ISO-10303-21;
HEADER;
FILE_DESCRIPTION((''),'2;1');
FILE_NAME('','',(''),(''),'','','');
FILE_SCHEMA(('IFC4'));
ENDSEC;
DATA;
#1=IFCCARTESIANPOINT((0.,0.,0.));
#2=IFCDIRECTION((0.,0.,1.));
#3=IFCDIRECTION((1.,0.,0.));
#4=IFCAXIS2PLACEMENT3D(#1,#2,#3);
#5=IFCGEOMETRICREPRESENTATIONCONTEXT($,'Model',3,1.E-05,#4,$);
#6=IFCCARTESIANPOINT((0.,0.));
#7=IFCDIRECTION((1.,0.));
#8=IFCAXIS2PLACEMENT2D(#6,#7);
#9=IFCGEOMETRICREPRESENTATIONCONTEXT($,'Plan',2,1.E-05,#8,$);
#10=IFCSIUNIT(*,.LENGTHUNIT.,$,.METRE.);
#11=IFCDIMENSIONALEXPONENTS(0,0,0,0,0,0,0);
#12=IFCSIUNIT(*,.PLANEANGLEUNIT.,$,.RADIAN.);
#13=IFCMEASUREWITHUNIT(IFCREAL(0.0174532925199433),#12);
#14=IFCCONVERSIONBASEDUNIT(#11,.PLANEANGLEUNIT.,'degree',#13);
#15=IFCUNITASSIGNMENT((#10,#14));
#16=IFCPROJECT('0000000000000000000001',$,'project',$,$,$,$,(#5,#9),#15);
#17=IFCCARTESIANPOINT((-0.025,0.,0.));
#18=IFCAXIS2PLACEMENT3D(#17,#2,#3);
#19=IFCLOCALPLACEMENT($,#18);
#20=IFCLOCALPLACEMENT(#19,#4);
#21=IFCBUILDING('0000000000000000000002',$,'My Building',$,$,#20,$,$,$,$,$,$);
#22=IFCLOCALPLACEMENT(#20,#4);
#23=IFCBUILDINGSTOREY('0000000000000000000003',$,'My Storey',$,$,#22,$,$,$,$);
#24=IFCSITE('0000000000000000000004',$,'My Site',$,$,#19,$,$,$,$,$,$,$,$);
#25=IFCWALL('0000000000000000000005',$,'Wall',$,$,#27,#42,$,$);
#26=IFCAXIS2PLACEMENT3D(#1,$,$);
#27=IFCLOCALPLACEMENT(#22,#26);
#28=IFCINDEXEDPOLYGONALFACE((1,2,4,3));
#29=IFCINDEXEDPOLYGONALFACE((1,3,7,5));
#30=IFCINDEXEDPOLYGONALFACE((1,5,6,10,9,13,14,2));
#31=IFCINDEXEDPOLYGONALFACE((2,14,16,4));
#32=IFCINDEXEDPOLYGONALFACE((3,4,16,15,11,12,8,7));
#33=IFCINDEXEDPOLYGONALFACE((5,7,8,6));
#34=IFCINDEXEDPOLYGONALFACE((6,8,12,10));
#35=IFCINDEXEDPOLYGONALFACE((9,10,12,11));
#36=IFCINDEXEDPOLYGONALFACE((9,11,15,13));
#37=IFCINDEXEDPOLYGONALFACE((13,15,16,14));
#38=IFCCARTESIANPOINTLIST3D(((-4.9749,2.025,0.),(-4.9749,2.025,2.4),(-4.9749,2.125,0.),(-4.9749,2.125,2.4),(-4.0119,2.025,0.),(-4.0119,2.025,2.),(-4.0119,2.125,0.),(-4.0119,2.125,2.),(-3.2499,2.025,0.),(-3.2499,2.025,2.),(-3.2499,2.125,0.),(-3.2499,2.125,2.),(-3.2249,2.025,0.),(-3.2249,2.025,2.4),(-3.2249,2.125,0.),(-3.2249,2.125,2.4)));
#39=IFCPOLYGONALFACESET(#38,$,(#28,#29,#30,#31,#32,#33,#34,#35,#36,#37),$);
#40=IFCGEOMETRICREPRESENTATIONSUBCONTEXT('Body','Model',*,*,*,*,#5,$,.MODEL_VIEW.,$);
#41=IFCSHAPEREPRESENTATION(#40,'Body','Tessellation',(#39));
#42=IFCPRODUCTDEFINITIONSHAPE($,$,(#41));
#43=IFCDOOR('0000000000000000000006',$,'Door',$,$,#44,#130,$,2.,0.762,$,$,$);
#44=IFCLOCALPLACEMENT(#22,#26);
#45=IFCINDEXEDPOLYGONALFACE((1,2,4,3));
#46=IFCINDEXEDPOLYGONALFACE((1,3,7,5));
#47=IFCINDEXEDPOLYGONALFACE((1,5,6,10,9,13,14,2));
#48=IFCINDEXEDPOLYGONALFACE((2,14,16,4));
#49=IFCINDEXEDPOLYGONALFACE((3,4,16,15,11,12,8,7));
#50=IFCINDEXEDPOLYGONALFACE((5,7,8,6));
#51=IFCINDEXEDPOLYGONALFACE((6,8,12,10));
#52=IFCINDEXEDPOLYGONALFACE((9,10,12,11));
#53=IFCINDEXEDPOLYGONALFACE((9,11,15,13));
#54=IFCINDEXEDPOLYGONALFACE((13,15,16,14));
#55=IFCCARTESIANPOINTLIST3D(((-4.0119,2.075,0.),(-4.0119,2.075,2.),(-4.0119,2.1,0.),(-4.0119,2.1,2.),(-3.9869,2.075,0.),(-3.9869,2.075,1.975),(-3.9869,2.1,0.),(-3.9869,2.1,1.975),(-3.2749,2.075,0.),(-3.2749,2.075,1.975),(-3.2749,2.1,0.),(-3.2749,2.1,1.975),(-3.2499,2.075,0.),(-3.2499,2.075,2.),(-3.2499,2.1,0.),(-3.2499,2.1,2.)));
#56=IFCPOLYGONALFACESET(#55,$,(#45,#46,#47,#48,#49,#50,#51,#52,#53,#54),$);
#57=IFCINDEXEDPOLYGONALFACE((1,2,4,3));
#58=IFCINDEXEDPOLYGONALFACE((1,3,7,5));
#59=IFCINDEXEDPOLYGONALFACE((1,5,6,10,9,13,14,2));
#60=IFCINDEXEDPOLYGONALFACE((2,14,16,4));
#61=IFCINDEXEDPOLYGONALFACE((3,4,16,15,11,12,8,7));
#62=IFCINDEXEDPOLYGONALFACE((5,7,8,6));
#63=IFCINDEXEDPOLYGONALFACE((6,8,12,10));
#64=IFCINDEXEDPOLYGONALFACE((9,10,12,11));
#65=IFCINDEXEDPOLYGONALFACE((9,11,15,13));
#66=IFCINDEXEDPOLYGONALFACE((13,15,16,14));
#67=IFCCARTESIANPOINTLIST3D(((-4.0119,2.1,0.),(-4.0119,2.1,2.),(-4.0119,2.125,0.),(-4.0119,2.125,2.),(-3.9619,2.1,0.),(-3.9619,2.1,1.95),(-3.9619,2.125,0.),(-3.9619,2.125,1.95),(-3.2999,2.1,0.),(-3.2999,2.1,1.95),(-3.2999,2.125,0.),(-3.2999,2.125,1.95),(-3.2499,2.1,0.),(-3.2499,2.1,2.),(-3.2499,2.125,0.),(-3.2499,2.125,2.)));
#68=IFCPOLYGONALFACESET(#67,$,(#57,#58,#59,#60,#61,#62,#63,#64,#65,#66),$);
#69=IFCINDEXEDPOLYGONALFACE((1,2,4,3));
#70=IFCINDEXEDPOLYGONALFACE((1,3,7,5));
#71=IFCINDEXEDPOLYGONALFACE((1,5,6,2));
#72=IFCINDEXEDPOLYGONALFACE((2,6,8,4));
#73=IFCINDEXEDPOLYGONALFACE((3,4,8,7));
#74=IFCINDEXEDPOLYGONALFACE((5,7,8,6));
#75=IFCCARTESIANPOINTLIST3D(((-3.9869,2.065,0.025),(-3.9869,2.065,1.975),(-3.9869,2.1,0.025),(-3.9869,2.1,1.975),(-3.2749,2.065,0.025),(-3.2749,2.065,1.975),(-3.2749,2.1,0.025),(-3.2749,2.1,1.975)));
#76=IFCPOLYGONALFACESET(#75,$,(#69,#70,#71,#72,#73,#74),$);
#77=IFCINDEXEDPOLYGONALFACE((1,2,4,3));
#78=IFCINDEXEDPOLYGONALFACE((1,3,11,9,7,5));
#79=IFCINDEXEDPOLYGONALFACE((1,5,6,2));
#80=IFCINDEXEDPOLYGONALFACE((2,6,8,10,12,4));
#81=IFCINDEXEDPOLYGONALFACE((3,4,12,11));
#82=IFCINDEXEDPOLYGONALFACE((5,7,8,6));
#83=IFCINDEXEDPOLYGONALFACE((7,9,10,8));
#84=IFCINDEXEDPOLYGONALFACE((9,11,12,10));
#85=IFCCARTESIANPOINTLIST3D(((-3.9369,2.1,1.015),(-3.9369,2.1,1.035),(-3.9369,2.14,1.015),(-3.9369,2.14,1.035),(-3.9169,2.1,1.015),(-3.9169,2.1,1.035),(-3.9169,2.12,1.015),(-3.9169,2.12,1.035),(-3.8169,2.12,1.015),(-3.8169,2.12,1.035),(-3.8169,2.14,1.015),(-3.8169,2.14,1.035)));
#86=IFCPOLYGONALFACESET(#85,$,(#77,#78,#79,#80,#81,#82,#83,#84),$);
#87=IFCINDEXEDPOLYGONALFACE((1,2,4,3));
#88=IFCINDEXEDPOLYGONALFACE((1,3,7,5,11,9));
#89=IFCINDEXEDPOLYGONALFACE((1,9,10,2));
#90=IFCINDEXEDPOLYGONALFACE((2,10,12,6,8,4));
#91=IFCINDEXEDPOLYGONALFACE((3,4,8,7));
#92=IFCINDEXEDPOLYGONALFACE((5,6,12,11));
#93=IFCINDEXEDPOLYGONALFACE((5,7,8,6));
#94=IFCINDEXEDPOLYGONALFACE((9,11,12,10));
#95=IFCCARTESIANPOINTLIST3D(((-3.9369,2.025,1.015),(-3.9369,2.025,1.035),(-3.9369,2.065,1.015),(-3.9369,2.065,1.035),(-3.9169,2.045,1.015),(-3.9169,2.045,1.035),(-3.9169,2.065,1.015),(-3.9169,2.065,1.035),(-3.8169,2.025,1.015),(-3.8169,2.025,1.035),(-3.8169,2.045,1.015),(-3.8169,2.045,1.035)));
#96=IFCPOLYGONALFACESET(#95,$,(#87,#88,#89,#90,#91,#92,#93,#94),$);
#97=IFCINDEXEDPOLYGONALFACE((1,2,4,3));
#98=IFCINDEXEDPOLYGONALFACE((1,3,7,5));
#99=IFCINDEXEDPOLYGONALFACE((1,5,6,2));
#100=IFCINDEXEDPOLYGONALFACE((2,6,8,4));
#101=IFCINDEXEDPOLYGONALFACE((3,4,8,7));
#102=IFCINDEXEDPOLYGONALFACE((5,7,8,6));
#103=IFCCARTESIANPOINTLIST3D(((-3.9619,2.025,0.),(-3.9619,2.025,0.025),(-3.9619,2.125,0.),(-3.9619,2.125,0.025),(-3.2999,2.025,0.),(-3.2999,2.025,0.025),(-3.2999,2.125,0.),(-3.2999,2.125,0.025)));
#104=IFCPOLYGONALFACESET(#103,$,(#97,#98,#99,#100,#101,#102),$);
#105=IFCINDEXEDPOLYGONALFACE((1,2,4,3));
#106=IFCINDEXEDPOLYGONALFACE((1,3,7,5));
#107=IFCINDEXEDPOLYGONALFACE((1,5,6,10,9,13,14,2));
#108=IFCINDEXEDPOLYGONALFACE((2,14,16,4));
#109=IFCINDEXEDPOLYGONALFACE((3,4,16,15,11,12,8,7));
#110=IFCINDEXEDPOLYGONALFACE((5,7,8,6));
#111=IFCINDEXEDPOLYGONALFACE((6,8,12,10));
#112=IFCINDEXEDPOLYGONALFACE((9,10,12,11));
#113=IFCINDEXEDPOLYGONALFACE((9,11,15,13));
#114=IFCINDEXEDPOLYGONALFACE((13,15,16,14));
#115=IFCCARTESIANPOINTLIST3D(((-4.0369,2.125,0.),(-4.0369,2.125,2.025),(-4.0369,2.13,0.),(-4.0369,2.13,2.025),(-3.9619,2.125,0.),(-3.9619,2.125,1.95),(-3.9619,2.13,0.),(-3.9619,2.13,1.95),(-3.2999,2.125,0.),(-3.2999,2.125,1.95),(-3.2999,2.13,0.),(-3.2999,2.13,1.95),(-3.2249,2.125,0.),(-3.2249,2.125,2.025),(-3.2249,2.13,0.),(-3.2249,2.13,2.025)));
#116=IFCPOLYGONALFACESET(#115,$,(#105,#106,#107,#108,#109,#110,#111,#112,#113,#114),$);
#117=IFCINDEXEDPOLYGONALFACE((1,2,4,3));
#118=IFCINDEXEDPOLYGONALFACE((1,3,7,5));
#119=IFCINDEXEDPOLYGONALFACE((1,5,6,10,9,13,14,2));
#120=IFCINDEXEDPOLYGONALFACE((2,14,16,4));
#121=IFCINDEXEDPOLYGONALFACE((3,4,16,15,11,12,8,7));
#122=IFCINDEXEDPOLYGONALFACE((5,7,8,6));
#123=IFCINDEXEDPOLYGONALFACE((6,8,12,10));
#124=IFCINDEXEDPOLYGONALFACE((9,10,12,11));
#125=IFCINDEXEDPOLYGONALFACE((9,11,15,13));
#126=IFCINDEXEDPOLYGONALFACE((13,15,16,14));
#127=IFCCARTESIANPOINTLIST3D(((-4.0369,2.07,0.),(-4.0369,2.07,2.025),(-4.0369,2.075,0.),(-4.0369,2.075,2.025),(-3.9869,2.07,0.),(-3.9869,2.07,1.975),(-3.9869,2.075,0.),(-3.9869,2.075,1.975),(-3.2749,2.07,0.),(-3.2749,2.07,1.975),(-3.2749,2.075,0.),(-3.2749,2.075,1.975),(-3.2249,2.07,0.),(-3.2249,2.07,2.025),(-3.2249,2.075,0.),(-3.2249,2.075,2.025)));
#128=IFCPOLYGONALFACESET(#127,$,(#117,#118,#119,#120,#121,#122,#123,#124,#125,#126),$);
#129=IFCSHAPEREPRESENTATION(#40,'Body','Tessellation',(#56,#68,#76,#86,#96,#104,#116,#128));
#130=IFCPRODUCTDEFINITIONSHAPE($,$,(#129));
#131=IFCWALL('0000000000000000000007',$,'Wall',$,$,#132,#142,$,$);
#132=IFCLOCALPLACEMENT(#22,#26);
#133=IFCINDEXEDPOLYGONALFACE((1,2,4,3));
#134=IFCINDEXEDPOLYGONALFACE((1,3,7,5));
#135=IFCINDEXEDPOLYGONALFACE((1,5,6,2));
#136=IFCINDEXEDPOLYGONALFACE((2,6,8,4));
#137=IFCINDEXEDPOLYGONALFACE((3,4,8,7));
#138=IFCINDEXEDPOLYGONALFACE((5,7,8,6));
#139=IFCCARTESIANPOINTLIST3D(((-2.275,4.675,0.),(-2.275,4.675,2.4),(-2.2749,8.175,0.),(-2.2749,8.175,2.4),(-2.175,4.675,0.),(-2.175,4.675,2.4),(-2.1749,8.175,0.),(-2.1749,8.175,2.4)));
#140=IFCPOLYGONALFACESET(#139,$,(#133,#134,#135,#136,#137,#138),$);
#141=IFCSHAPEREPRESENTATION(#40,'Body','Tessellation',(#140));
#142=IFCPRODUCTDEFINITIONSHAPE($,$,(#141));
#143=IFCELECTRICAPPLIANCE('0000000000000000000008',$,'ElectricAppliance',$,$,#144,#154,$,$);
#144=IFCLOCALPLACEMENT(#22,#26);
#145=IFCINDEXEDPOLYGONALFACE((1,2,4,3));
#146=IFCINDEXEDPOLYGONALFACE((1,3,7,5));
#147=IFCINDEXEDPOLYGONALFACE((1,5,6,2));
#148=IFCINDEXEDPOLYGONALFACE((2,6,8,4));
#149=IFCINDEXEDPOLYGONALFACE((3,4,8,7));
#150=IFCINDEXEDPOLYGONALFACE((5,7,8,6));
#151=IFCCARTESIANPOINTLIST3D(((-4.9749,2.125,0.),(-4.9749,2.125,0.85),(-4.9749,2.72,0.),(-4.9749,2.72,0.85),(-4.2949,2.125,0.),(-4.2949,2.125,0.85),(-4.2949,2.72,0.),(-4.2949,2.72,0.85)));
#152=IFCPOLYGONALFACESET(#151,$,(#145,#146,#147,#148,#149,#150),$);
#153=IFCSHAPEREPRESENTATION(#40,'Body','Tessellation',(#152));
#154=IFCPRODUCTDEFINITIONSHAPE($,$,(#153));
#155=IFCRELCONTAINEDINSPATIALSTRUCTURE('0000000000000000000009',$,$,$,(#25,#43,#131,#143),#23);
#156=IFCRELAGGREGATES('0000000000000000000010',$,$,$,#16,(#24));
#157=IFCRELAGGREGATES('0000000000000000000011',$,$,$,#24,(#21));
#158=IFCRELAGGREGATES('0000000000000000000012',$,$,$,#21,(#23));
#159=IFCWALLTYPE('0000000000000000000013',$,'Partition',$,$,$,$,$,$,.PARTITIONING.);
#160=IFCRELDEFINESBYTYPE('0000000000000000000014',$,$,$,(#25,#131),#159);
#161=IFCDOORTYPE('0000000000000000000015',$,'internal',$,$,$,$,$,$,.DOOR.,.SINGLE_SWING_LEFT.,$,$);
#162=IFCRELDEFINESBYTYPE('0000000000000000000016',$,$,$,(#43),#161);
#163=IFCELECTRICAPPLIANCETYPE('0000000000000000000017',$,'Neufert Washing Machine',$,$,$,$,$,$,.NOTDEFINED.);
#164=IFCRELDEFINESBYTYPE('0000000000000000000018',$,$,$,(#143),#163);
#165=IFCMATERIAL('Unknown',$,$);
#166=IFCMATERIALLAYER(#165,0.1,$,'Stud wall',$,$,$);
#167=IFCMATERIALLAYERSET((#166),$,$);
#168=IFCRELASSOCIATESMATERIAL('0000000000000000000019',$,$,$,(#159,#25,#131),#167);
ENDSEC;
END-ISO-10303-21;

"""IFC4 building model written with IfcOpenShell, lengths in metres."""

from ifc_helpers import new_model, entity, si_unit, converted_unit, frame, origin_with_axes, origin_2d_with_axis, place, context, subcontext, project, spatial, line, indexed_curve, outline, extrude, shape, source, transform, mapped, material, layer, layer_set, layer_usage, type_object, type_shapes, element, fill, save


model = new_model("IFC4")

# Units and contexts
model_context = context("Model", 3, precision=1e-05, world=origin_with_axes())
plan_context = context("Plan", 2, precision=1e-05, world=origin_2d_with_axis())
body_context_1 = subcontext(model_context, "Body", "Model", "MODEL_VIEW")
body_context_2 = subcontext(plan_context, "Body", "Plan", "PLAN_VIEW")
ifc_project = project(units=[si_unit("LENGTHUNIT", "METRE"), converted_unit("PLANEANGLEUNIT", "degree", entity("IfcReal", 0.0174532925199433), si_unit("PLANEANGLEUNIT", "RADIAN"), dimensions=[0, 0, 0, 0, 0, 0, 0])], contexts=[model_context, plan_context])

# Site, building, storey
site_placement = place(None, frame((-0.025, 0.0, 0.0), z_axis=(0.0, 0.0, 1.0), x_axis=(1.0, 0.0, 0.0)))
site = spatial("IfcSite", under=ifc_project, at=site_placement, Name="My Site")
building_placement = place(site_placement, origin_with_axes())
building = spatial("IfcBuilding", under=site, at=building_placement, Name="My Building")
storey_placement = place(building_placement, origin_with_axes())
storey = spatial("IfcBuildingStorey", under=building, at=storey_placement, Name="My Storey")

# Shared definitions
ifc_material = material(Name="Unknown")
shared_shape_1 = source(origin_with_axes(), body_context_1, "Body", "SweptSolid", [
    extrude(outline(indexed_curve([(0.0, 0.0), (0.762, 0.0), (0.762, 2.0), (0.0, 2.0)], segments=[line(1, 2, 3, 4, 1)])), frame((0.0, -0.6, 0.0), z_axis=(0.0, -1.0, 0.0), x_axis=(1.0, 0.0, 0.0)), (0.0, 0.0, -1.0), 1.2),
])
door_type = type_object("IfcDoorType", Name="internal", OperationType="SINGLE_SWING_LEFT", PredefinedType="DOOR")
shared_shape_2 = source(origin_with_axes(), body_context_1, "Body", "SweptSolid", [
    extrude(outline(indexed_curve([(0.0, 0.0), (0.0, 2.0), (0.762, 2.0), (0.762, 0.0), (0.737, 0.0), (0.737, 1.975), (0.025, 1.975), (0.025, 0.0)], segments=[line(1, 2, 3, 4, 5, 6, 7, 8, 1)])), frame((0.0, 0.025, 0.0), z_axis=(0.0, -1.0, 0.0), x_axis=(1.0, 0.0, 0.0)), (0.0, 0.0, -1.0), 0.025),
    extrude(outline(indexed_curve([(0.0, 0.0), (0.0, 2.0), (0.762, 2.0), (0.762, 0.0), (0.712, 0.0), (0.712, 1.95), (0.05, 1.95), (0.05, 0.0)], segments=[line(1, 2, 3, 4, 5, 6, 7, 8, 1)])), frame((0.0, 0.0, 0.0), z_axis=(0.0, -1.0, 0.0), x_axis=(1.0, 0.0, 0.0)), (0.0, 0.0, -1.0), 0.025),
    extrude(outline(indexed_curve([(0.0, 0.0), (0.712, 0.0), (0.712, 0.035), (0.0, 0.035)], segments=[line(1, 2, 3, 4, 1)])), frame((0.025, 0.025, 0.025), z_axis=(0.0, 0.0, 1.0), x_axis=(1.0, 0.0, 0.0)), (0.0, 0.0, 1.0), 1.95),
    extrude(outline(indexed_curve([(0.0, 0.0), (0.0, -0.04), (-0.12, -0.04), (-0.12, -0.02), (-0.02, -0.02), (-0.02, 0.0)], segments=[line(1, 2, 3, 4, 5, 6, 1)])), frame((0.687, 0.025, 1.015), z_axis=(0.0, 0.0, 1.0), x_axis=(1.0, 0.0, 0.0)), (0.0, 0.0, 1.0), 0.02),
    extrude(outline(indexed_curve([(0.0, 0.0), (0.0, 0.04), (-0.12, 0.04), (-0.12, 0.02), (-0.02, 0.02), (-0.02, 0.0)], segments=[line(1, 2, 3, 4, 5, 6, 1)])), frame((0.687, 0.06, 1.015), z_axis=(0.0, 0.0, 1.0), x_axis=(1.0, 0.0, 0.0)), (0.0, 0.0, 1.0), 0.02),
    extrude(outline(indexed_curve([(0.0, 0.0), (0.662, 0.0), (0.662, 0.1), (0.0, 0.1)], segments=[line(1, 2, 3, 4, 1)])), frame((0.05, 0.0, 0.0), z_axis=(0.0, 0.0, 1.0), x_axis=(1.0, 0.0, 0.0)), (0.0, 0.0, 1.0), 0.025),
    extrude(outline(indexed_curve([(0.0, 0.0), (0.0, 2.025), (0.812, 2.025), (0.812, 0.0), (0.737, 0.0), (0.737, 1.95), (0.075, 1.95), (0.075, 0.0)], segments=[line(1, 2, 3, 4, 5, 6, 7, 8, 1)])), frame((-0.025, -0.005, 0.0), z_axis=(0.0, -1.0, 0.0), x_axis=(1.0, 0.0, 0.0)), (0.0, 0.0, -1.0), 0.005),
    extrude(outline(indexed_curve([(0.0, 0.0), (0.0, 2.025), (0.812, 2.025), (0.812, 0.0), (0.762, 0.0), (0.762, 1.975), (0.05, 1.975), (0.05, 0.0)], segments=[line(1, 2, 3, 4, 5, 6, 7, 8, 1)])), frame((-0.025, 0.05, 0.0), z_axis=(0.0, -1.0, 0.0), x_axis=(1.0, 0.0, 0.0)), (0.0, 0.0, -1.0), 0.005),
])
shared_shape_3 = source(origin_with_axes(), body_context_2, "Body", "Curve2D", [
    entity("IfcIndexedPolyCurve", entity("IfcCartesianPointList2D", [[0.0, 0.0], [0.0, 0.05], [0.025, 0.05], [0.025, 0.025], [0.05, 0.025], [0.05, 0.0]]), [entity("IfcLineIndex", [1, 2, 3, 4, 5, 6, 1])]),
    entity("IfcIndexedPolyCurve", entity("IfcCartesianPointList2D", [[0.762, 0.0], [0.762, 0.05], [0.737, 0.05], [0.737, 0.025], [0.712, 0.025], [0.712, 0.0]]), [entity("IfcLineIndex", [1, 2, 3, 4, 5, 6, 1])]),
    entity("IfcTrimmedCurve", entity("IfcEllipse", entity("IfcAxis2Placement2D", entity("IfcCartesianPoint", [0.06, 0.05]), entity("IfcDirection", [1.0, 0.0])), 0.677, 0.712), [entity("IfcCartesianPoint", [0.737, 0.05])], [entity("IfcCartesianPoint", [0.06, 0.762])], True, "CARTESIAN"),
    entity("IfcIndexedPolyCurve", entity("IfcCartesianPointList2D", [[0.025, 0.05], [0.06, 0.05], [0.06, 0.762], [0.025, 0.762]]), [entity("IfcLineIndex", [1, 2, 3, 4, 1])]),
])
type_shapes(door_type, [shared_shape_2, shared_shape_3])

# Wall, opening, door
ifc_layer_1 = layer(ifc_material, 0.1, Name="Stud wall")
ifc_layer_set_1 = layer_set([ifc_layer_1])
wall_type_1 = type_object("IfcWallType", Name="Partition", PredefinedType="PARTITIONING", material=ifc_layer_set_1)
ifc_layer_usage_1 = layer_usage(ifc_layer_set_1, "AXIS2", "POSITIVE", 0.0)
wall_1_placement = place(storey_placement, frame((-3.2249, 2.125, 0.0), z_axis=(0.0, 0.0, 1.0), x_axis=(-1.0, 0.0, 0.0)))
wall_1 = element("IfcWall", 1, at=wall_1_placement, inside=storey, type_object=wall_type_1, material=ifc_layer_usage_1, Name="Wall", context=body_context_1, shape_type="SweptSolid", body=[
    extrude(outline(indexed_curve([(0.0, 0.0), (0.0, 0.1), (1.75, 0.1), (1.75, 0.0), (0.0, 0.0)], self_intersect=False)), origin_with_axes(), (0.0, 0.0, 1.0), 2.4),
])
opening_1_placement = place(wall_1_placement, frame((0.025, 0.0, 0.0), z_axis=(0.0, 0.0, 1.0), x_axis=(1.0, 0.0, 0.0)))
opening_1 = element("IfcOpeningElement", 2, at=opening_1_placement, cuts=wall_1, PredefinedType="OPENING", context=body_context_1, shape_type="MappedRepresentation", body=[
    mapped(shared_shape_1, transform((0.0, 0.0, 0.0), x_axis=(1.0, 0.0, 0.0), y_axis=(0.0, 1.0, 0.0), z_axis=(0.0, 0.0, 1.0), scale=1.0)),
])
door_1_placement = place(opening_1_placement, frame((0.0, 0.0, 0.0), z_axis=(0.0, 0.0, 1.0), x_axis=(1.0, 0.0, 0.0)))
door_1 = element("IfcDoor", 3, at=door_1_placement, inside=storey, type_object=door_type, Name="Door", OverallHeight=2.0, OverallWidth=0.762, shapes=[
    shape(body_context_1, "Body", "MappedRepresentation", [mapped(shared_shape_2, transform((0.0, 0.0, 0.0), x_axis=(1.0, 0.0, 0.0), y_axis=(0.0, 1.0, 0.0), z_axis=(0.0, 0.0, 1.0), scale=1.0))]),
    shape(body_context_2, "Body", "MappedRepresentation", [mapped(shared_shape_3, transform((0.0, 0.0, 0.0), x_axis=(1.0, 0.0, 0.0), y_axis=(0.0, 1.0, 0.0), z_axis=(0.0, 0.0, 1.0), scale=1.0))]),
])
fill(opening_1, door_1)

# Wall
ifc_layer_usage_2 = layer_usage(ifc_layer_set_1, "AXIS2", "POSITIVE", 0.0)
wall_2_placement = place(storey_placement, frame((-2.175, 4.675, 0.0), z_axis=(0.0, 0.0, 1.0), x_axis=(0.0, 1.0, 0.0)))
element("IfcWall", 4, at=wall_2_placement, inside=storey, type_object=wall_type_1, material=ifc_layer_usage_2, Name="Wall", context=body_context_1, shape_type="SweptSolid", body=[
    extrude(outline(indexed_curve([(0.0, 0.0), (0.0, 0.1), (3.5, 0.1), (3.5, 0.0), (0.0, 0.0)], self_intersect=False)), origin_with_axes(), (0.0, 0.0, 1.0), 2.4),
])

# Electric appliance
electric_appliance_type_1 = type_object("IfcElectricApplianceType", Name="Neufert Washing Machine", PredefinedType="NOTDEFINED")
shared_shape_4 = source(origin_with_axes(), body_context_1, "Body", "SweptSolid", [
    extrude(outline(indexed_curve([(0.0, 0.0), (0.595, 0.0), (0.595, 0.68), (0.0, 0.68)], segments=[line(1, 2, 3, 4, 1)])), origin_with_axes(), (0.0, 0.0, 1.0), 0.85),
])
shared_shape_5 = source(origin_with_axes(), body_context_2, "Body", "Curve2D", [
    entity("IfcIndexedPolyCurve", entity("IfcCartesianPointList2D", [[0.0, 0.0], [0.595, 0.0], [0.595, 0.68], [0.0, 0.68]]), [entity("IfcLineIndex", [1, 2, 3, 4, 1])]),
    entity("IfcCircle", entity("IfcAxis2Placement2D", entity("IfcCartesianPoint", [0.2975, 0.34])), 0.1785),
    entity("IfcCircle", entity("IfcAxis2Placement2D", entity("IfcCartesianPoint", [0.2975, 0.34])), 0.0595),
])
type_shapes(electric_appliance_type_1, [shared_shape_4, shared_shape_5])
electric_appliance_1_placement = place(storey_placement, frame((-4.2949, 2.125, 0.0), z_axis=(0.0, 0.0, 1.0), x_axis=(0.0, 1.0, 0.0)))
element("IfcElectricAppliance", 5, at=electric_appliance_1_placement, inside=storey, type_object=electric_appliance_type_1, Name="ElectricAppliance", shapes=[
    shape(body_context_1, "Body", "MappedRepresentation", [mapped(shared_shape_4, transform((0.0, 0.0, 0.0), x_axis=(1.0, 0.0, 0.0), y_axis=(0.0, 1.0, 0.0), z_axis=(0.0, 0.0, 1.0), scale=1.0))]),
    shape(body_context_2, "Body", "MappedRepresentation", [mapped(shared_shape_5, transform((0.0, 0.0, 0.0), x_axis=(1.0, 0.0, 0.0), y_axis=(0.0, 1.0, 0.0), z_axis=(0.0, 0.0, 1.0), scale=1.0))]),
])

save(model, "model.ifc")
